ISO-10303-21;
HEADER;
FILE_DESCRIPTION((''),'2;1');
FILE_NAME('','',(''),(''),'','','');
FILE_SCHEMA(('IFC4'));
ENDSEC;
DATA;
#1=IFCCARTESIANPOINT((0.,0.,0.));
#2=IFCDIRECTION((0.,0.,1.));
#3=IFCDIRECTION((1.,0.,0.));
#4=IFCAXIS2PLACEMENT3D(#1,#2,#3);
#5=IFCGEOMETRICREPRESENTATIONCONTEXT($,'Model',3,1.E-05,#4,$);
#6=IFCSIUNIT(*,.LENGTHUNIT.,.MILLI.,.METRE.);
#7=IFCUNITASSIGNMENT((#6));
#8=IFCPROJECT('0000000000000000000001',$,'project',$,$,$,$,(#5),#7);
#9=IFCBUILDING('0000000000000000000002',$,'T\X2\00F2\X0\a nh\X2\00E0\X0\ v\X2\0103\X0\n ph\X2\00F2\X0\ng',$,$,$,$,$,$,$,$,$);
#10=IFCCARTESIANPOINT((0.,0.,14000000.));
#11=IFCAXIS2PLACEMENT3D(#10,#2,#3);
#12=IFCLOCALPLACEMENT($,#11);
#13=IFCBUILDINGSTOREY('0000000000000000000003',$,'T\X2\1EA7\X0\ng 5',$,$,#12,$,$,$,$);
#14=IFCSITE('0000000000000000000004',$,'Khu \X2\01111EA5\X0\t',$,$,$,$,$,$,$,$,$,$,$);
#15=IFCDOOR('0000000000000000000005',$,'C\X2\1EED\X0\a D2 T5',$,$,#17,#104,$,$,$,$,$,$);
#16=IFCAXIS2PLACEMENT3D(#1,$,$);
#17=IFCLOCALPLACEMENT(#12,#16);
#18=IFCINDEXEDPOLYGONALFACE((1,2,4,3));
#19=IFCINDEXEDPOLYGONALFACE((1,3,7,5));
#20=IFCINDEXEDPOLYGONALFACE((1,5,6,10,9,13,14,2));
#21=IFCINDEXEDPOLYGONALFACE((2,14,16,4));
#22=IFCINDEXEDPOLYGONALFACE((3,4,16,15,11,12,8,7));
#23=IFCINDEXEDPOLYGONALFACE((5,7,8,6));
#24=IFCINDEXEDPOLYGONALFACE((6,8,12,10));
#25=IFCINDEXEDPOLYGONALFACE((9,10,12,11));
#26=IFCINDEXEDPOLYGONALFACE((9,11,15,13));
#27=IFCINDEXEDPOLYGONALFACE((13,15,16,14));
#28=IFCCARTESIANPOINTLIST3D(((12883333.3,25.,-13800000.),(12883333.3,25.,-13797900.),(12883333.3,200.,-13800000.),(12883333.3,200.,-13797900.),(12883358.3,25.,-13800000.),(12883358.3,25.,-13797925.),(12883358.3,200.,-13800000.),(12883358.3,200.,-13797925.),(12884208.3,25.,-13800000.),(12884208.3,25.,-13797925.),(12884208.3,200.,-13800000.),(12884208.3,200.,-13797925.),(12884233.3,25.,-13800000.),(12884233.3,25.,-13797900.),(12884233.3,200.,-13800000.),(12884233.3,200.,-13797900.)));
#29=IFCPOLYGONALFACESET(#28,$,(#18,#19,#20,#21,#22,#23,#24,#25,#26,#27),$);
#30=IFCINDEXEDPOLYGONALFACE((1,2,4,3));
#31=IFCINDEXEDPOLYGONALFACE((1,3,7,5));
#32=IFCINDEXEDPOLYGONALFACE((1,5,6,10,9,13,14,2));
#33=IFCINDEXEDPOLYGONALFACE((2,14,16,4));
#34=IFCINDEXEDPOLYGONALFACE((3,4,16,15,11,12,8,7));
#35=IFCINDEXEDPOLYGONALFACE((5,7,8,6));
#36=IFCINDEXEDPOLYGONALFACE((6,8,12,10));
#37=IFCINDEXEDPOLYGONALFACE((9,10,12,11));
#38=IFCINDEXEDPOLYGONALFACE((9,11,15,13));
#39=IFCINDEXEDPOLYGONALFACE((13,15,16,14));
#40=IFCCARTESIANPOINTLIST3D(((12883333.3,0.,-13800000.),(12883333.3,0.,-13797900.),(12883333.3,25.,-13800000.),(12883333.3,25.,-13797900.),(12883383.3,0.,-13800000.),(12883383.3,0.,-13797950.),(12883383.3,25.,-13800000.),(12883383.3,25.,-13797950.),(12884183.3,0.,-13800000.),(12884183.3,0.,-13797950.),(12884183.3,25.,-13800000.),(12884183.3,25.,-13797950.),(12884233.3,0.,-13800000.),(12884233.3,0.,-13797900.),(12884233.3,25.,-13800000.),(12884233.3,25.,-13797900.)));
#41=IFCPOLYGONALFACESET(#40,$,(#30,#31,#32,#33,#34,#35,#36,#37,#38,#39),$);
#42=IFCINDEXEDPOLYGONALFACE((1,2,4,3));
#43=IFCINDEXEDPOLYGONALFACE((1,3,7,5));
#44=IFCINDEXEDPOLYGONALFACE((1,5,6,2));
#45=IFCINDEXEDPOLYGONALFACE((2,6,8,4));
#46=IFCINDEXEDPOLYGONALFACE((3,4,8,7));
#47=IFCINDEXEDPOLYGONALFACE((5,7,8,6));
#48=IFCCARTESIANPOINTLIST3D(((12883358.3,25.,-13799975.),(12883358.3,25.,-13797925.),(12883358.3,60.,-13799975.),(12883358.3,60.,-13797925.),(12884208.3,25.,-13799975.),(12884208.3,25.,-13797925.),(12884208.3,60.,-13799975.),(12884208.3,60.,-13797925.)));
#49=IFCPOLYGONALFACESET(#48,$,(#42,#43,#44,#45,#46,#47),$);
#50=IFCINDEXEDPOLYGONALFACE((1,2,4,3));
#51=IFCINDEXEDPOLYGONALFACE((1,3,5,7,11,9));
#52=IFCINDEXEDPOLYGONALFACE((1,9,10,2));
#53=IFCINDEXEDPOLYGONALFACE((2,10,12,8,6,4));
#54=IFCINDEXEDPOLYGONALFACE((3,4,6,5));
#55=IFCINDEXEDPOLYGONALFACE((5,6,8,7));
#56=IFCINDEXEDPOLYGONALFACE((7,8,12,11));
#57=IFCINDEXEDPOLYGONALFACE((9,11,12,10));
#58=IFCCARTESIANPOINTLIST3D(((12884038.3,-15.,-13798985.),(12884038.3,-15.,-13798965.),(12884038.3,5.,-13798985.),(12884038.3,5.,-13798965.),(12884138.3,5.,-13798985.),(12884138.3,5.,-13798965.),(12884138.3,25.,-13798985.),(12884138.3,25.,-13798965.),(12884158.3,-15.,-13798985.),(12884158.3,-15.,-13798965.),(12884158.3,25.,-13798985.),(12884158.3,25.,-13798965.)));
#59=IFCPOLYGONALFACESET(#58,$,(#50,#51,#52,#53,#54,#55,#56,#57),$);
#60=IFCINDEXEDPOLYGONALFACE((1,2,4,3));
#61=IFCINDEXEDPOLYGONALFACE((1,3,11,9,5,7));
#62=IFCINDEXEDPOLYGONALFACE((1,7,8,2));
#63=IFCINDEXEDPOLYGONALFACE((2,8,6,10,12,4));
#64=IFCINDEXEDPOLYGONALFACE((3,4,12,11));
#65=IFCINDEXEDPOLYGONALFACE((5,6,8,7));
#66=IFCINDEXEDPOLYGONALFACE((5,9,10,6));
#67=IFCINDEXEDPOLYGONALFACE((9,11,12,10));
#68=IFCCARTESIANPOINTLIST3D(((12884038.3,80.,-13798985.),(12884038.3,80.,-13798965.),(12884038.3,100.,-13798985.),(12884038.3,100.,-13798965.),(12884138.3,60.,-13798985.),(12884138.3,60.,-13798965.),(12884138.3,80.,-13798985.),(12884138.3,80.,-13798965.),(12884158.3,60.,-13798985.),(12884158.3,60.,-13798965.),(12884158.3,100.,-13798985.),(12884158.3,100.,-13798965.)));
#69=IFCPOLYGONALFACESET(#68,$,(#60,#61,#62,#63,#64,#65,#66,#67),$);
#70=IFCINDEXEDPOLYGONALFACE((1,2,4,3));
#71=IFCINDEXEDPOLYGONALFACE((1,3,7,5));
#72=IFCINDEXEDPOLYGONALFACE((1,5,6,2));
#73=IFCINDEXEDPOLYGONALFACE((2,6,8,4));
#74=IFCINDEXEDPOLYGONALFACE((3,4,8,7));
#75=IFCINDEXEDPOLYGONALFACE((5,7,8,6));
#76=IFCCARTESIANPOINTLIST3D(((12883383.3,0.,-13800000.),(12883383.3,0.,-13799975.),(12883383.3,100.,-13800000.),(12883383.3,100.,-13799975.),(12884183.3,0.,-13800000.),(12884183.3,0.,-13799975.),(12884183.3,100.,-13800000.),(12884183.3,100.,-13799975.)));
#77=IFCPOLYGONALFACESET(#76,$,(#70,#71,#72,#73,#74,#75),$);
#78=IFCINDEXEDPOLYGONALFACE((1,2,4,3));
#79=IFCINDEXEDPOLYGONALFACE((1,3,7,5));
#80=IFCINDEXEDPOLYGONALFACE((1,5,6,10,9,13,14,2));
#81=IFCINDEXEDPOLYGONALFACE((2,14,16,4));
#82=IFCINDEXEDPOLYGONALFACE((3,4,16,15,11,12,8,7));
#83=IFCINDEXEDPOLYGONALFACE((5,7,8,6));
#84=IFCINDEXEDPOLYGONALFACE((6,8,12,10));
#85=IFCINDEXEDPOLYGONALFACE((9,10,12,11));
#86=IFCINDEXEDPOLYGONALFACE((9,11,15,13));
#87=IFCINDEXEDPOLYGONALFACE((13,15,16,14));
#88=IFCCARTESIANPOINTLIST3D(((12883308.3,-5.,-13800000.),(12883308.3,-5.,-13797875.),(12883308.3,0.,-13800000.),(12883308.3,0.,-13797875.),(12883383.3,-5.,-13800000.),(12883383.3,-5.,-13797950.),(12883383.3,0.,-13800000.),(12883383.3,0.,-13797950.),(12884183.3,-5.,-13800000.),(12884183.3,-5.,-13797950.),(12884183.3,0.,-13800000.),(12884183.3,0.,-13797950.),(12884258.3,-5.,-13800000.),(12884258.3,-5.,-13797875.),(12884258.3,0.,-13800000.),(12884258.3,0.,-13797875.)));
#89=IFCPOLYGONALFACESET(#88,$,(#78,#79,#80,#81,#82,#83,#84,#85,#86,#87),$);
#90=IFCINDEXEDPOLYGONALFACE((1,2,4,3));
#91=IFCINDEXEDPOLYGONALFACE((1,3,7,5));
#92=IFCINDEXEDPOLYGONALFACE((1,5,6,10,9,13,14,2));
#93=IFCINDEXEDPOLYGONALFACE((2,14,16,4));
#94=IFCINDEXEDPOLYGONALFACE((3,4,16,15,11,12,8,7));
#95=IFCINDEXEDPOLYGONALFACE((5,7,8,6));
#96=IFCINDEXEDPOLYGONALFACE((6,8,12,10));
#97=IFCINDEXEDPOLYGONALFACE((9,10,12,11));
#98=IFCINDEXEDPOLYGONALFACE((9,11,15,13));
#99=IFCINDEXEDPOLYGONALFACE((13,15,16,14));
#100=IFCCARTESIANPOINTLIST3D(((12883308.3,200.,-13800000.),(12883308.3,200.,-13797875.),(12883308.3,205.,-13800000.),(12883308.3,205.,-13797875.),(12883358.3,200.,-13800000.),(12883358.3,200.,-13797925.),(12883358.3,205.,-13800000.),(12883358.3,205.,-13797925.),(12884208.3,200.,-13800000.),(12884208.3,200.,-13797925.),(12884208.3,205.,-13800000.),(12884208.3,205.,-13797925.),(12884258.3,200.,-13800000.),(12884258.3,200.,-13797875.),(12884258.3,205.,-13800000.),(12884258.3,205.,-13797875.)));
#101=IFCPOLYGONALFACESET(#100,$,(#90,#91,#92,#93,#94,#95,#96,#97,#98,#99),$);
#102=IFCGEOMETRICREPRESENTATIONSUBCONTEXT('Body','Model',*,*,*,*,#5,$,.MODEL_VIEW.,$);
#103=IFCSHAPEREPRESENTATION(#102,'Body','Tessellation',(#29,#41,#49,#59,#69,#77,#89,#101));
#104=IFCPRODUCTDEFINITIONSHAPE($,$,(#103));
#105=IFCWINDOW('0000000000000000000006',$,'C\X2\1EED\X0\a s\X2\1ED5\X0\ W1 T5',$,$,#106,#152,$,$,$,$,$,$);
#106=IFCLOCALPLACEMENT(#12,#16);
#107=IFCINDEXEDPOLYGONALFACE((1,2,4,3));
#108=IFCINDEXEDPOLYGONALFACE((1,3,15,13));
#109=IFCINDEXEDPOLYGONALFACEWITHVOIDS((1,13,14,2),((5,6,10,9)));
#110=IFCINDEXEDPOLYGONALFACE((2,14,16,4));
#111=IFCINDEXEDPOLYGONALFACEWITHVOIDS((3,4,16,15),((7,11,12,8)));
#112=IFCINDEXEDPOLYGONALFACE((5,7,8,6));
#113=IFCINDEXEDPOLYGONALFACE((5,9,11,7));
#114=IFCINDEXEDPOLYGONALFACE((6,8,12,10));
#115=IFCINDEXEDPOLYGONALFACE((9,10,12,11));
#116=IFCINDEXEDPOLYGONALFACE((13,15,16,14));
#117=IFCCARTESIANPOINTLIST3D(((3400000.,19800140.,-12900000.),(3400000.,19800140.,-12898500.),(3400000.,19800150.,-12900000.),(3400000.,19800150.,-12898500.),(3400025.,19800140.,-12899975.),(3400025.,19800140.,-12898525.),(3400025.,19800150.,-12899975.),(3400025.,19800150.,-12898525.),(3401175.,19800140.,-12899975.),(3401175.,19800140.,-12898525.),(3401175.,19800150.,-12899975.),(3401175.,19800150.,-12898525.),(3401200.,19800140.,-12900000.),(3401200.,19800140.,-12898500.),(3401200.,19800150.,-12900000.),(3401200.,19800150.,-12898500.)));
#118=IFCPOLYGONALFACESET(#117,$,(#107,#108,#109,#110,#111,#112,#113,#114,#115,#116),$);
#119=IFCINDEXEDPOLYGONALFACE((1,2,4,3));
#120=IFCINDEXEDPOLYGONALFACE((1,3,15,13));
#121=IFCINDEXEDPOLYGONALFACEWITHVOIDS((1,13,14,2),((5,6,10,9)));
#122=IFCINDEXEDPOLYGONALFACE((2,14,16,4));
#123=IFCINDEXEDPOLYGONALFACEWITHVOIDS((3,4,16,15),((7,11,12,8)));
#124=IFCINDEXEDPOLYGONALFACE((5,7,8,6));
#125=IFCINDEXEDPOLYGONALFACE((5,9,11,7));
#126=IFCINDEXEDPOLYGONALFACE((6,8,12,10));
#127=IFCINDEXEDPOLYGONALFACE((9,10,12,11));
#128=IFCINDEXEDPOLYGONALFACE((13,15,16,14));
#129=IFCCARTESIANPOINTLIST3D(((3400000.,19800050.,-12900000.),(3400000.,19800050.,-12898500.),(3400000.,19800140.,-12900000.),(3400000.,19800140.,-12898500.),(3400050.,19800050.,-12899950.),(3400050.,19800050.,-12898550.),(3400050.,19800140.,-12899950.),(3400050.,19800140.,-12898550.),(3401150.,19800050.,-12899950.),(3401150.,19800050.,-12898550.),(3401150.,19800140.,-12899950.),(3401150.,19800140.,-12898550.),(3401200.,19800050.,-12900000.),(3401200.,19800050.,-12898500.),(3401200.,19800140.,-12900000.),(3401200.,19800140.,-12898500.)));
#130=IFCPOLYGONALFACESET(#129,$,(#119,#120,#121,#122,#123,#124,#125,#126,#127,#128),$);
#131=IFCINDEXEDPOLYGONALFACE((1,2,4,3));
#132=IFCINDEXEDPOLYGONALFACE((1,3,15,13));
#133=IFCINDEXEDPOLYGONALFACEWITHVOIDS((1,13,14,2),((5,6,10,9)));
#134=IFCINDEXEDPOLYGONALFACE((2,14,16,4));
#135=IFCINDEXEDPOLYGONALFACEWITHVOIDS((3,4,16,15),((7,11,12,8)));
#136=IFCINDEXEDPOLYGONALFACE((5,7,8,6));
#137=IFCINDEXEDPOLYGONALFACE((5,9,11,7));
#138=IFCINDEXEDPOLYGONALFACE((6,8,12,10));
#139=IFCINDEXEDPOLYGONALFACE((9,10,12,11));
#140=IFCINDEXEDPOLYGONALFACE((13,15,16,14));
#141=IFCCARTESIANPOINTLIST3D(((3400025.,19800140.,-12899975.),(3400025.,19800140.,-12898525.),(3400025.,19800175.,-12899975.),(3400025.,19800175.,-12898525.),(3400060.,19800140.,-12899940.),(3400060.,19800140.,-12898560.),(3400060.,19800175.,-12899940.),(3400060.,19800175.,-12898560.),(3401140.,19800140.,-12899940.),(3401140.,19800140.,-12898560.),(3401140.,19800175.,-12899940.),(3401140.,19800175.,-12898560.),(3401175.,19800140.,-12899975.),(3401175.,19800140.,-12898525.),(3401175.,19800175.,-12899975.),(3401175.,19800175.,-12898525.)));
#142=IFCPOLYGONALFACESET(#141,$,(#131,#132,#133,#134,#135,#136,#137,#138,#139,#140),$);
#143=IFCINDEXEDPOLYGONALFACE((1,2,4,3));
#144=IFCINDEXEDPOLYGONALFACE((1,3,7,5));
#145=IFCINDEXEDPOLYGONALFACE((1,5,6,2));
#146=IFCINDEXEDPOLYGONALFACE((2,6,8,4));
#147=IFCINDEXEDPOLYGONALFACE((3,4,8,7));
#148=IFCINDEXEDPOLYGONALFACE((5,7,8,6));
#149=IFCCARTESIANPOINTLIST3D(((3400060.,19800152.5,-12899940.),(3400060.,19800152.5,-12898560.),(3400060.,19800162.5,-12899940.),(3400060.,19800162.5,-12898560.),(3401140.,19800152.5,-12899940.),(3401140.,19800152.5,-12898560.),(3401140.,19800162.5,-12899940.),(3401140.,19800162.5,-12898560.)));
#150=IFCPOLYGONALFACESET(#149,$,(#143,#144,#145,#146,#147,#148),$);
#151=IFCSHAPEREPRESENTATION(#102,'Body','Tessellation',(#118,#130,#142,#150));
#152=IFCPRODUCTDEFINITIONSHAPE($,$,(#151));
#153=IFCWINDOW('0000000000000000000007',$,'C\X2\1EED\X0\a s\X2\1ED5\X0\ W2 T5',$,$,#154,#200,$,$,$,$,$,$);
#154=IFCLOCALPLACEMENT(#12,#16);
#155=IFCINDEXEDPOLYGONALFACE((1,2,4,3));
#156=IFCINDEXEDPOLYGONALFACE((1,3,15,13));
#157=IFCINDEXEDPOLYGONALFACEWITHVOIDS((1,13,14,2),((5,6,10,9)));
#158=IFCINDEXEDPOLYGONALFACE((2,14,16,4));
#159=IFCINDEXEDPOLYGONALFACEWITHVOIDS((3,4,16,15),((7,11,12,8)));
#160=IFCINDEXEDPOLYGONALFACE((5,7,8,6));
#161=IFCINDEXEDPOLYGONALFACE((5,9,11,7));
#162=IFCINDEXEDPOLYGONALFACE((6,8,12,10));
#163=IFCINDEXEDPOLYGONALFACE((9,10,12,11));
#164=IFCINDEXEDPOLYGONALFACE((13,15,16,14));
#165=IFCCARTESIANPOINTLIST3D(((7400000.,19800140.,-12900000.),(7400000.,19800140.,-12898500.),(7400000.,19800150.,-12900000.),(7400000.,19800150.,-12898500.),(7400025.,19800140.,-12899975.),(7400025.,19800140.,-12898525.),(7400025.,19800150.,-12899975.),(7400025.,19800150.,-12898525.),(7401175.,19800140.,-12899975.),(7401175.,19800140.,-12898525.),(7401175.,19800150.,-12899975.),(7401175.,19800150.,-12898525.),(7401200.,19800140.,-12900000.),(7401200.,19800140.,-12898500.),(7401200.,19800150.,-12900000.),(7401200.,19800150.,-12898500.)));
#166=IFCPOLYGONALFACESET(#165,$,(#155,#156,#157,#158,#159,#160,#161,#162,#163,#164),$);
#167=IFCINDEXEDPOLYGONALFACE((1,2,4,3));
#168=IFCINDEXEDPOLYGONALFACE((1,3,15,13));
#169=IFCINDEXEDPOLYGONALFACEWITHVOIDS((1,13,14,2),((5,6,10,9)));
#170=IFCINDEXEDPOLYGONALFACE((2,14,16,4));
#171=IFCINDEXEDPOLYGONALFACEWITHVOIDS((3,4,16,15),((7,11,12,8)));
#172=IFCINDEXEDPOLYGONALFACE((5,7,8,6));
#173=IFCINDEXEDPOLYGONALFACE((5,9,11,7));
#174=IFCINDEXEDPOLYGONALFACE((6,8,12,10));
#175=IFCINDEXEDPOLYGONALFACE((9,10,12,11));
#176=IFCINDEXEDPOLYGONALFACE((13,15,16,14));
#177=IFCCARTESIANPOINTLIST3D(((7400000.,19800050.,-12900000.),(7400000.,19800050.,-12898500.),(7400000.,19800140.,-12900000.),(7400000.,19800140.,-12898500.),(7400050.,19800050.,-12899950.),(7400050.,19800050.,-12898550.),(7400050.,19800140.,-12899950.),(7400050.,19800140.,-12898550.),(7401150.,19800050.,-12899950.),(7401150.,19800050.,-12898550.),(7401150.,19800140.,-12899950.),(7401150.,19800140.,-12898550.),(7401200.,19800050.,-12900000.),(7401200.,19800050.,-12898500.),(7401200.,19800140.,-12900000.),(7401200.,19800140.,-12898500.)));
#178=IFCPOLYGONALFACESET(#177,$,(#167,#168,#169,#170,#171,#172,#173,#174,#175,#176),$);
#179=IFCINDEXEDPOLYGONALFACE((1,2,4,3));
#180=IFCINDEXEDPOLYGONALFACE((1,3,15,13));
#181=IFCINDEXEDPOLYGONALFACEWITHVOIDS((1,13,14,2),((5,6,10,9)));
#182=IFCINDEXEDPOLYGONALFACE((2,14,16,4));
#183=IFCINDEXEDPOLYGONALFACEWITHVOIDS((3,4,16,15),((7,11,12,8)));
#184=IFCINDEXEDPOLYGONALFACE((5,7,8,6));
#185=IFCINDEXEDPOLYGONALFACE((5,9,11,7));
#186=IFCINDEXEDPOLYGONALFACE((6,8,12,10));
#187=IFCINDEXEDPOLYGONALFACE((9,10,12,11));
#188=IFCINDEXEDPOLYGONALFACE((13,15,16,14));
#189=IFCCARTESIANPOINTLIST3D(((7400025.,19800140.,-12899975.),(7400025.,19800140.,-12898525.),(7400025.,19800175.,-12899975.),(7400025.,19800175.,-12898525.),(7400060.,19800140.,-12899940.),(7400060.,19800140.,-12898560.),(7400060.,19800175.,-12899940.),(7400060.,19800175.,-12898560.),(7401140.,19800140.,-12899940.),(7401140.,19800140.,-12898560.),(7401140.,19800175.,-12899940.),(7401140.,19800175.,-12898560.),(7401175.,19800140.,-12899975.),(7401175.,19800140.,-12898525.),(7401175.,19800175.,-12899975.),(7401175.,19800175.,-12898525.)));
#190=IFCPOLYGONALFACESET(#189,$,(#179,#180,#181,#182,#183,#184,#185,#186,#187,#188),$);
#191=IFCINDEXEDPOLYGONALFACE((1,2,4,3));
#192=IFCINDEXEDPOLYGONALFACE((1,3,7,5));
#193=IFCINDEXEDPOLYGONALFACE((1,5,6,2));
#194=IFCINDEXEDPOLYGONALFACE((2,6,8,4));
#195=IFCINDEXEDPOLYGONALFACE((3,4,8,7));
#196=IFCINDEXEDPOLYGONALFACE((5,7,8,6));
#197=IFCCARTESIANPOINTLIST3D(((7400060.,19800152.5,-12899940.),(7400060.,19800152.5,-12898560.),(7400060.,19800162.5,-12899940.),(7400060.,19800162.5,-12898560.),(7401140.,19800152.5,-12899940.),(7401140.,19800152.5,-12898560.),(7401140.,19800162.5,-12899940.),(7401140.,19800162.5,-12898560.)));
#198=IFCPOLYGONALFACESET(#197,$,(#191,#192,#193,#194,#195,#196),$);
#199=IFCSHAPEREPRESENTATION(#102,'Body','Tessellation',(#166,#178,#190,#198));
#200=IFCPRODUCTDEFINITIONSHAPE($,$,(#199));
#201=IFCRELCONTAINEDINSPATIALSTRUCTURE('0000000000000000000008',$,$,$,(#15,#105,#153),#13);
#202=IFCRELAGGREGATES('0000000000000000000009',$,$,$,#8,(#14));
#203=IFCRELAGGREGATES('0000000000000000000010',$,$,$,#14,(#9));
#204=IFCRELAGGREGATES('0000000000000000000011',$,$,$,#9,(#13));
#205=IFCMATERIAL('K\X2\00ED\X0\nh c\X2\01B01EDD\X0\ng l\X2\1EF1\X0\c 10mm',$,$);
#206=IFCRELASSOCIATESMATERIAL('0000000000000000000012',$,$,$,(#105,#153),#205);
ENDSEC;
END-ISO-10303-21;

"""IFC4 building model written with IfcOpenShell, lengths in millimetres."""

from ifc_helpers import new_model, si_unit, frame, origin_with_axes, place, context, subcontext, project, spatial, line, indexed_curve, outline, extrude, material, element, save


model = new_model("IFC4")

# Units and contexts
model_context = context("Model", 3, precision=1e-05, world=origin_with_axes())
body_context = subcontext(model_context, "Body", "Model", "MODEL_VIEW")
ifc_project = project(units=[si_unit("LENGTHUNIT", "METRE", prefix="MILLI")], contexts=[model_context])

# Site, building, storey
site = spatial("IfcSite", under=ifc_project, Name="Khu đất")
building = spatial("IfcBuilding", under=site, Name="Tòa nhà văn phòng")
storey_placement = place(None, frame((0.0, 0.0, 14000000.0), z_axis=(0.0, 0.0, 1.0), x_axis=(1.0, 0.0, 0.0)))
storey = spatial("IfcBuildingStorey", under=building, at=storey_placement, Name="Tầng 5")

# Door
door_1_placement = place(storey_placement, frame((12883333.3, 0.0, -13800000.0), z_axis=(0.0, 0.0, 1.0), x_axis=(1.0, 0.0, 0.0)))
element("IfcDoor", 1, at=door_1_placement, inside=storey, Name="Cửa D2 T5", context=body_context, shape_type="SolidModel", body=[
    extrude(outline(indexed_curve([(0.0, 0.0), (0.0, 2100.0), (900.0, 2100.0), (900.0, 0.0), (875.0, 0.0), (875.0, 2075.0), (25.0, 2075.0), (25.0, 0.0)], segments=[line(1, 2, 3, 4, 5, 6, 7, 8, 1)])), frame((0.0, 25.0, 0.0), z_axis=(0.0, -1.0, 0.0), x_axis=(1.0, 0.0, 0.0)), (0.0, 0.0, -1.0), 175.0),
    extrude(outline(indexed_curve([(0.0, 0.0), (0.0, 2100.0), (900.0, 2100.0), (900.0, 0.0), (850.0, 0.0), (850.0, 2050.0), (50.0, 2050.0), (50.0, 0.0)], segments=[line(1, 2, 3, 4, 5, 6, 7, 8, 1)])), frame((0.0, 0.0, 0.0), z_axis=(0.0, -1.0, 0.0), x_axis=(1.0, 0.0, 0.0)), (0.0, 0.0, -1.0), 25.0),
    extrude(outline(indexed_curve([(0.0, 0.0), (850.0, 0.0), (850.0, 35.0), (0.0, 35.0)], segments=[line(1, 2, 3, 4, 1)])), frame((25.0, 25.0, 25.0), z_axis=(0.0, 0.0, 1.0), x_axis=(1.0, 0.0, 0.0)), (0.0, 0.0, 1.0), 2050.0),
    extrude(outline(indexed_curve([(0.0, 0.0), (0.0, -40.0), (-120.0, -40.0), (-120.0, -20.0), (-20.0, -20.0), (-20.0, 0.0)], segments=[line(1, 2, 3, 4, 5, 6, 1)])), frame((825.0, 25.0, 1015.0), z_axis=(0.0, 0.0, 1.0), x_axis=(1.0, 0.0, 0.0)), (0.0, 0.0, 1.0), 20.0),
    extrude(outline(indexed_curve([(0.0, 0.0), (0.0, 40.0), (-120.0, 40.0), (-120.0, 20.0), (-20.0, 20.0), (-20.0, 0.0)], segments=[line(1, 2, 3, 4, 5, 6, 1)])), frame((825.0, 60.0, 1015.0), z_axis=(0.0, 0.0, 1.0), x_axis=(1.0, 0.0, 0.0)), (0.0, 0.0, 1.0), 20.0),
    extrude(outline(indexed_curve([(0.0, 0.0), (800.0, 0.0), (800.0, 100.0), (0.0, 100.0)], segments=[line(1, 2, 3, 4, 1)])), frame((50.0, 0.0, 0.0), z_axis=(0.0, 0.0, 1.0), x_axis=(1.0, 0.0, 0.0)), (0.0, 0.0, 1.0), 25.0),
    extrude(outline(indexed_curve([(0.0, 0.0), (0.0, 2125.0), (950.0, 2125.0), (950.0, 0.0), (875.0, 0.0), (875.0, 2050.0), (75.0, 2050.0), (75.0, 0.0)], segments=[line(1, 2, 3, 4, 5, 6, 7, 8, 1)])), frame((-25.0, -5.0, 0.0), z_axis=(0.0, -1.0, 0.0), x_axis=(1.0, 0.0, 0.0)), (0.0, 0.0, -1.0), 5.0),
    extrude(outline(indexed_curve([(0.0, 0.0), (0.0, 2125.0), (950.0, 2125.0), (950.0, 0.0), (900.0, 0.0), (900.0, 2075.0), (50.0, 2075.0), (50.0, 0.0)], segments=[line(1, 2, 3, 4, 5, 6, 7, 8, 1)])), frame((-25.0, 200.0, 0.0), z_axis=(0.0, -1.0, 0.0), x_axis=(1.0, 0.0, 0.0)), (0.0, 0.0, -1.0), 5.0),
])

# Windows
ifc_material_1 = material(Name="Kính cường lực 10mm")
for number, where, z_axis, x_axis, name in (
    (2, (3400000.0, 19800000.0, -12900000.0), (0.0, 0.0, 1.0), (1.0, 0.0, 0.0), "Cửa sổ W1 T5"),
    (3, (7400000.0, 19800000.0, -12900000.0), (0.0, 0.0, 1.0), (1.0, 0.0, 0.0), "Cửa sổ W2 T5"),
):
    element("IfcWindow", number, at=place(storey_placement, frame(where, z_axis=z_axis, x_axis=x_axis)), inside=storey, material=ifc_material_1, Name=name, context=body_context, shape_type="SolidModel", body=[
        extrude(outline(indexed_curve([(0.0, 0.0), (1200.0, 0.0), (1200.0, 1500.0), (0.0, 1500.0)], segments=[line(1, 2, 3, 4, 1)]), holes=[indexed_curve([(25.0, 25.0), (1175.0, 25.0), (1175.0, 1475.0), (25.0, 1475.0)], segments=[line(1, 2, 3, 4, 1)])]), frame((0.0, 140.0, 0.0), z_axis=(0.0, -1.0, 0.0), x_axis=(1.0, 0.0, 0.0)), (0.0, 0.0, -1.0), 10.0),
        extrude(outline(indexed_curve([(0.0, 0.0), (1200.0, 0.0), (1200.0, 1500.0), (0.0, 1500.0)], segments=[line(1, 2, 3, 4, 1)]), holes=[indexed_curve([(50.0, 50.0), (1150.0, 50.0), (1150.0, 1450.0), (50.0, 1450.0)], segments=[line(1, 2, 3, 4, 1)])]), frame((0.0, 50.0, 0.0), z_axis=(0.0, -1.0, 0.0), x_axis=(1.0, 0.0, 0.0)), (0.0, 0.0, -1.0), 90.0),
        extrude(outline(indexed_curve([(0.0, 0.0), (1150.0, 0.0), (1150.0, 1450.0), (0.0, 1450.0)], segments=[line(1, 2, 3, 4, 1)]), holes=[indexed_curve([(35.0, 35.0), (1115.0, 35.0), (1115.0, 1415.0), (35.0, 1415.0)], segments=[line(1, 2, 3, 4, 1)])]), frame((25.0, 140.0, 25.0), z_axis=(0.0, -1.0, 0.0), x_axis=(1.0, 0.0, 0.0)), (0.0, 0.0, -1.0), 35.0),
        extrude(outline(indexed_curve([(35.0, 35.0), (1115.0, 35.0), (1115.0, 1415.0), (35.0, 1415.0)], segments=[line(1, 2, 3, 4, 1)])), frame((25.0, 152.5, 25.0), z_axis=(0.0, -1.0, 0.0), x_axis=(1.0, 0.0, 0.0)), (0.0, 0.0, -1.0), 10.0),
    ])

save(model, "model.ifc")
